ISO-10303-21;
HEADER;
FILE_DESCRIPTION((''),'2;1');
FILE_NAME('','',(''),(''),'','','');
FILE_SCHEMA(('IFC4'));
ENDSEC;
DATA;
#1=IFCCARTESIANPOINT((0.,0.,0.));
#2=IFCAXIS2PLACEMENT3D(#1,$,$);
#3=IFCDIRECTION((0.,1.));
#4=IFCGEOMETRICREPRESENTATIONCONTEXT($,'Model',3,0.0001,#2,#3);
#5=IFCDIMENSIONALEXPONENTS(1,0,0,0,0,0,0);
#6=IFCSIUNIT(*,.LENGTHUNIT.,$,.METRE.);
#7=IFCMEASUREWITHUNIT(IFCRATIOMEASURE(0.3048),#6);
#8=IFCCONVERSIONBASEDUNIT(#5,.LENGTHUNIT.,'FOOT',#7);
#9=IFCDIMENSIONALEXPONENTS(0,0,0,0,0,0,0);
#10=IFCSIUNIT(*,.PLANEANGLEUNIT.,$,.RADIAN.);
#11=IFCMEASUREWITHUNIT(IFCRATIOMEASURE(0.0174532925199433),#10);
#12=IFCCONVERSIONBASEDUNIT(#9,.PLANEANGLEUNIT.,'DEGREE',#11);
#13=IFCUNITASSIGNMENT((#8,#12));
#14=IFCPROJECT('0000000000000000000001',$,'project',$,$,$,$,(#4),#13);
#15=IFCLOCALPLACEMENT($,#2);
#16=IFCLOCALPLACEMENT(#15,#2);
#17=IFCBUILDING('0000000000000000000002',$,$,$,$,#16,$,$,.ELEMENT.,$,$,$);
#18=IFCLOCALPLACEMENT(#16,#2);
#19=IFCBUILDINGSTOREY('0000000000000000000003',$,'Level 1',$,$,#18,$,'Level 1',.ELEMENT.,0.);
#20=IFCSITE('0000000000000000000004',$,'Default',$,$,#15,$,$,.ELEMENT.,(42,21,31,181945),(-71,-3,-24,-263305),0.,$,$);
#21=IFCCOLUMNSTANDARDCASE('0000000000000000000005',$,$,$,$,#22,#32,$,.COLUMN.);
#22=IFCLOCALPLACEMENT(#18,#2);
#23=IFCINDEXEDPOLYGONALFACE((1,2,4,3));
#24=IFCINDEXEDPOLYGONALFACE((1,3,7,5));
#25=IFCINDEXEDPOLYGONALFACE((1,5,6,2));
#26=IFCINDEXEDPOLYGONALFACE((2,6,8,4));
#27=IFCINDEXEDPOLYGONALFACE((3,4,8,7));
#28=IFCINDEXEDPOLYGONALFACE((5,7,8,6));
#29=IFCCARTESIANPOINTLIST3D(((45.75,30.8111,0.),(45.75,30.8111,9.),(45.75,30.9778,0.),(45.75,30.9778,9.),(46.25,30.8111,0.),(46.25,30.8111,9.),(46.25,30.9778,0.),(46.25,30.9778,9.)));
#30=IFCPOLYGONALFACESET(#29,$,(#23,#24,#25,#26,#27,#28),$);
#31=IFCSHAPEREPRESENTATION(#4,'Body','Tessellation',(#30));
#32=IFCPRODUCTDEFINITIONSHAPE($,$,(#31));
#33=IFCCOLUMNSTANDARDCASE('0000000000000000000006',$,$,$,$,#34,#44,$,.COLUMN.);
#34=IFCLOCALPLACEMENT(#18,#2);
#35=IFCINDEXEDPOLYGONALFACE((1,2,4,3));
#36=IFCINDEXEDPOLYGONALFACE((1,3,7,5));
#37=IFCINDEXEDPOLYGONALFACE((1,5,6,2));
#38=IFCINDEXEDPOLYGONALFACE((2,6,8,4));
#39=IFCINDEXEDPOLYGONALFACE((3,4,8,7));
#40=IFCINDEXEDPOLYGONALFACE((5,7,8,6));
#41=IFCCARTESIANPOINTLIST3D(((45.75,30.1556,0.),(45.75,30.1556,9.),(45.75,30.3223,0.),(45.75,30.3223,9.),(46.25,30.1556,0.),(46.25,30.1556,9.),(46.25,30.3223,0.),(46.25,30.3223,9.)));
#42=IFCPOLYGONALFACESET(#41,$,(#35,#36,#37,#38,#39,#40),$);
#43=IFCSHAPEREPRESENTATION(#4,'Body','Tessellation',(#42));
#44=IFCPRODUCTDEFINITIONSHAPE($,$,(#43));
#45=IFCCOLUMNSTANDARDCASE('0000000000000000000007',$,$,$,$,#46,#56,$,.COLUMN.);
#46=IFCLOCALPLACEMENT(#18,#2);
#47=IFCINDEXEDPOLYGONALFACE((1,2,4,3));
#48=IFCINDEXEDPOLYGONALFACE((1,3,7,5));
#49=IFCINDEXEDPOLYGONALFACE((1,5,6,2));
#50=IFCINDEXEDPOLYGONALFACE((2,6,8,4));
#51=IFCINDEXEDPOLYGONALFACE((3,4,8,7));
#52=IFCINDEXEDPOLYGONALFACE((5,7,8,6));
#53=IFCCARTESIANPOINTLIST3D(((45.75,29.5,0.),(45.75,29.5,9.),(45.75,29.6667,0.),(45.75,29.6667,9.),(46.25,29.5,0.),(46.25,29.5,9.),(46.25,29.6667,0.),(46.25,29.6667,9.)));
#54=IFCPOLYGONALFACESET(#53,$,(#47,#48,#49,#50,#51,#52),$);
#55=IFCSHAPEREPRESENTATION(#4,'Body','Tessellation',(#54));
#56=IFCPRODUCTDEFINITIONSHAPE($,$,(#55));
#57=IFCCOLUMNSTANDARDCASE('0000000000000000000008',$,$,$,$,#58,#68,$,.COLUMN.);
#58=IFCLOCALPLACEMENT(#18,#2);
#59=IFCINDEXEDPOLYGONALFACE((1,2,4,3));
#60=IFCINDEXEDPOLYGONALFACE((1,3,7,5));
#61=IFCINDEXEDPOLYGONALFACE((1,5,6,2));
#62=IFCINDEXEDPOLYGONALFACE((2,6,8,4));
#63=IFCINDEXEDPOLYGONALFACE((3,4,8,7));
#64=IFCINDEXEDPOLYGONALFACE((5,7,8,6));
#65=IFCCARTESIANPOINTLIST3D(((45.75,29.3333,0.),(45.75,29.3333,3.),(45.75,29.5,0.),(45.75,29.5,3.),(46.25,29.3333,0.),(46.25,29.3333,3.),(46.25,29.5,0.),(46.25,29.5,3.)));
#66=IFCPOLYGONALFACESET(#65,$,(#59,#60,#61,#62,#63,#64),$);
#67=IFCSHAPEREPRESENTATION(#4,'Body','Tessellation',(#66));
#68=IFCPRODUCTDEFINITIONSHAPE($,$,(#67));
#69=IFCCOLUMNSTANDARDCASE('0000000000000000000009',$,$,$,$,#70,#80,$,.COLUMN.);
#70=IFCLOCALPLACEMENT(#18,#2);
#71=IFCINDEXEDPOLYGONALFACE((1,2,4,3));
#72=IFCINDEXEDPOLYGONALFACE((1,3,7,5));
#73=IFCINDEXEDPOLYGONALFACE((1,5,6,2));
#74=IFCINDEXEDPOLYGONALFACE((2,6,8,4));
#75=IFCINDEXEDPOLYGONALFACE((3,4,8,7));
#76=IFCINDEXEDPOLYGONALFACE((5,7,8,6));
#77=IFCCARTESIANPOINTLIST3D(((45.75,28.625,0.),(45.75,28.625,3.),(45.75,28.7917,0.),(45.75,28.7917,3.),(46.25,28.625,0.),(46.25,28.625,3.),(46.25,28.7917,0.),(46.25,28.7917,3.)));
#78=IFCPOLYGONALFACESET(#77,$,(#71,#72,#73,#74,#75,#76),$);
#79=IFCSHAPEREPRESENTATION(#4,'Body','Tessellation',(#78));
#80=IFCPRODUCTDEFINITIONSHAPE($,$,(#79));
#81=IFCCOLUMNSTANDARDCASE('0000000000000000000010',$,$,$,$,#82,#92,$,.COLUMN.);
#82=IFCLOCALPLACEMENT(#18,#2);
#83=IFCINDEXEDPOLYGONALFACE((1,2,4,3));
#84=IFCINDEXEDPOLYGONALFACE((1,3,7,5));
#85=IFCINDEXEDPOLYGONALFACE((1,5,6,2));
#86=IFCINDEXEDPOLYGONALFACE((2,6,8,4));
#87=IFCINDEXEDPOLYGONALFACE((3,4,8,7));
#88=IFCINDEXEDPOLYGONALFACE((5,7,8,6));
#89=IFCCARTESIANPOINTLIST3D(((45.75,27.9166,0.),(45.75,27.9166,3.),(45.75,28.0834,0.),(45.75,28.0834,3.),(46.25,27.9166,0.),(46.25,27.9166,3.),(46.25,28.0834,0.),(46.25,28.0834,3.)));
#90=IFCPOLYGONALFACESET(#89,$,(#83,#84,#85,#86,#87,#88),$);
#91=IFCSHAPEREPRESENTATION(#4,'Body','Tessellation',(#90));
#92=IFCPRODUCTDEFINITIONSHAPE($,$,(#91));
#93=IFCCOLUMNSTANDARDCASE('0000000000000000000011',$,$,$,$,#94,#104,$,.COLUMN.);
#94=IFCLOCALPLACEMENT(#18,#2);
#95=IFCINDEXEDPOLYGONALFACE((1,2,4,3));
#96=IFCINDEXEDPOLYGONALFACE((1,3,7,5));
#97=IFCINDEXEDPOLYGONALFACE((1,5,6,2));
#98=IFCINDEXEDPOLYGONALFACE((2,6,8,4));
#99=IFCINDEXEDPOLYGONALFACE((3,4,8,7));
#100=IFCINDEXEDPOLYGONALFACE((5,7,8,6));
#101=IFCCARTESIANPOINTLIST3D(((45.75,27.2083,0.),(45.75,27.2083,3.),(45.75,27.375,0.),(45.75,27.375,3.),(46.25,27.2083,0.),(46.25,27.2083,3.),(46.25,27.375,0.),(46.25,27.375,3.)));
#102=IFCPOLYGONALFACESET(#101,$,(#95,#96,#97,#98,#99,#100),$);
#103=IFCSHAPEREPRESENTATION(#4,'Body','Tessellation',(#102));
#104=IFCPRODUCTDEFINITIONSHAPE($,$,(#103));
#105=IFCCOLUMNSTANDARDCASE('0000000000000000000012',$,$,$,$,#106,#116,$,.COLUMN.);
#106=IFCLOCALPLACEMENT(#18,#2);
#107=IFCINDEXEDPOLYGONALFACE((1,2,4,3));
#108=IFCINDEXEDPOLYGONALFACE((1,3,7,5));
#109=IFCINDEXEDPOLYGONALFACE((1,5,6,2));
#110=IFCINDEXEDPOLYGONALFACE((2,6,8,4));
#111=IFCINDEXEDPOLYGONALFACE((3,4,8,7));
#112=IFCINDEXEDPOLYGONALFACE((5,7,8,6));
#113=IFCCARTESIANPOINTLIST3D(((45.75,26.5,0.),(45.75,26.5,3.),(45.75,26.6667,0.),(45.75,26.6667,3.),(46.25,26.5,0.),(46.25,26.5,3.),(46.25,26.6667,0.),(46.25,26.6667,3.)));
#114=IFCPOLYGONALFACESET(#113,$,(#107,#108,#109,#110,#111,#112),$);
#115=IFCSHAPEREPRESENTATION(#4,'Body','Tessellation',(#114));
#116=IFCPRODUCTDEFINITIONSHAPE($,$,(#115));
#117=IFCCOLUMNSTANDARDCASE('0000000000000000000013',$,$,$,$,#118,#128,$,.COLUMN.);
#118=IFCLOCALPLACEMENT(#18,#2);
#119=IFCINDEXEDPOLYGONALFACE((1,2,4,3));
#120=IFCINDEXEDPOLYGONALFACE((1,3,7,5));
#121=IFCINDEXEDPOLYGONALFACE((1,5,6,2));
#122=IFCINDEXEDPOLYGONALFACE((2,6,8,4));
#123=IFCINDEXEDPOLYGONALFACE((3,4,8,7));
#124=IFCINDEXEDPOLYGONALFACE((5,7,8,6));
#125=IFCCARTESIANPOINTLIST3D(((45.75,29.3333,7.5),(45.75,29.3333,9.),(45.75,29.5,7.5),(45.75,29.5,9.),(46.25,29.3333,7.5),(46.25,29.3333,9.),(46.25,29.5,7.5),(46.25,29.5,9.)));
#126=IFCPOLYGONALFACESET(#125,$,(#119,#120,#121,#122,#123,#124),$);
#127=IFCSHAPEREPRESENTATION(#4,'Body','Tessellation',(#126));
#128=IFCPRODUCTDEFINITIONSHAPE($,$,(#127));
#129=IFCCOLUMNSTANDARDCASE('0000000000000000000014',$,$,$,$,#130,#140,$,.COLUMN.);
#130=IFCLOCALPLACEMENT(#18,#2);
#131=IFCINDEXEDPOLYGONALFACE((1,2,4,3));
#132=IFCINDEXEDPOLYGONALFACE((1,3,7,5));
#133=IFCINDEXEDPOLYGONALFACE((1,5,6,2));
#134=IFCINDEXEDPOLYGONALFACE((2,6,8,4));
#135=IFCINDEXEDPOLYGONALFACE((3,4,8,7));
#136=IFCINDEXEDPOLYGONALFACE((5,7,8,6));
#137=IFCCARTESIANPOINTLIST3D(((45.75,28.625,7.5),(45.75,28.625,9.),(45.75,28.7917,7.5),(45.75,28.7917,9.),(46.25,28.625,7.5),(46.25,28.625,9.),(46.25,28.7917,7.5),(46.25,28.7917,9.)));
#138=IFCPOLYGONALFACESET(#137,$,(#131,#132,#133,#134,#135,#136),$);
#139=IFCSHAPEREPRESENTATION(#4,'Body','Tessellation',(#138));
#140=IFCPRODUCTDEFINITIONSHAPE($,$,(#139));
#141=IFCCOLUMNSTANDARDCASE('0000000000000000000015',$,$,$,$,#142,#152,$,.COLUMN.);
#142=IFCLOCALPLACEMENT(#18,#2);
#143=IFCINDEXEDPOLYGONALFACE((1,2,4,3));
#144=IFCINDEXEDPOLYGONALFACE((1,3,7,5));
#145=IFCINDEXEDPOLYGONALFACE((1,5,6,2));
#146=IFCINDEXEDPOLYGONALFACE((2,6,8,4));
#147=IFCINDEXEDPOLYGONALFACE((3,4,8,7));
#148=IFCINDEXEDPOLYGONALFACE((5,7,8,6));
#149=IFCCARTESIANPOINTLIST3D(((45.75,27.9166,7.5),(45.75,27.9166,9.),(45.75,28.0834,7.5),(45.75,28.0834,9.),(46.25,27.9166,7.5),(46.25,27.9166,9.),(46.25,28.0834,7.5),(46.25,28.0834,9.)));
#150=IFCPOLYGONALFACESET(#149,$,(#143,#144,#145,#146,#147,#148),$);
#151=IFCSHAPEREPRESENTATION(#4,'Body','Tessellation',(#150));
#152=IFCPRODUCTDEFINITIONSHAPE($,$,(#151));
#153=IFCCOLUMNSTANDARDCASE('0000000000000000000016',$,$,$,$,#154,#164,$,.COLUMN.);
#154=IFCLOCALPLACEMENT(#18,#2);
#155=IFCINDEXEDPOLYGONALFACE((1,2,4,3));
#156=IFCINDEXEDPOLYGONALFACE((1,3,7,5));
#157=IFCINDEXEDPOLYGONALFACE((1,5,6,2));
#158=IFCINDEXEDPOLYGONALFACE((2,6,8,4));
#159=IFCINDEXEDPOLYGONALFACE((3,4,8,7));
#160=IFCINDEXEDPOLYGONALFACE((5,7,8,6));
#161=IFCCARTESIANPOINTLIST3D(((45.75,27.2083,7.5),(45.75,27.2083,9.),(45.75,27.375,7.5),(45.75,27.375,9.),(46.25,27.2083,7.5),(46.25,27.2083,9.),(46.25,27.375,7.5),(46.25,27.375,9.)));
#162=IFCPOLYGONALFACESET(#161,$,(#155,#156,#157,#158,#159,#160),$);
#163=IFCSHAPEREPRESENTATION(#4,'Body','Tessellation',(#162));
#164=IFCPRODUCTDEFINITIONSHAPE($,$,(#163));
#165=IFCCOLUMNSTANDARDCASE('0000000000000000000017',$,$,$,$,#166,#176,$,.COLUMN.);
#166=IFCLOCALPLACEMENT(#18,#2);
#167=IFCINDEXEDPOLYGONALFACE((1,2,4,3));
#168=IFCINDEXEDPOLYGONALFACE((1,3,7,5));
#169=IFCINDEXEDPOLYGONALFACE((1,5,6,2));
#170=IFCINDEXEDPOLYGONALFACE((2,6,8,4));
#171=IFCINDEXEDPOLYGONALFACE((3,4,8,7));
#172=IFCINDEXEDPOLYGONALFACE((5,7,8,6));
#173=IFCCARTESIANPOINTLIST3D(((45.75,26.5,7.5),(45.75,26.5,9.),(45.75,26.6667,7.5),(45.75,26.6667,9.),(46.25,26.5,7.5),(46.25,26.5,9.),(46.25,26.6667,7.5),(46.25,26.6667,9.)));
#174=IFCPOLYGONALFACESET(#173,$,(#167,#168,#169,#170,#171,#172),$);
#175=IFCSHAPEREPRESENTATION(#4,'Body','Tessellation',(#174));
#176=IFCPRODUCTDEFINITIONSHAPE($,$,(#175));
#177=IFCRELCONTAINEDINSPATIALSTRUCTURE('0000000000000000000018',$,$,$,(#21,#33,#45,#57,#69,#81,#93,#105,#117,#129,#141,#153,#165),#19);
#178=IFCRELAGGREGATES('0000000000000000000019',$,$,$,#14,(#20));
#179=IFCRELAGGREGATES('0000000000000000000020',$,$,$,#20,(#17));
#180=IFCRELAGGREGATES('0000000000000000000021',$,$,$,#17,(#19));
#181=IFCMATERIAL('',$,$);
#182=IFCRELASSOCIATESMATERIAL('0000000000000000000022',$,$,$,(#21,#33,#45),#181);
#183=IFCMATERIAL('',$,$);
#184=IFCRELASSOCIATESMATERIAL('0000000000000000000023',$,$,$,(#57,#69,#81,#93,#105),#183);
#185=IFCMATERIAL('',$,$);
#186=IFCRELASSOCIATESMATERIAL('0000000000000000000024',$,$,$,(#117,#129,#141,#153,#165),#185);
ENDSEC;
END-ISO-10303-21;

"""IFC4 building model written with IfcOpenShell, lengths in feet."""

from ifc_helpers import new_model, entity, si_unit, converted_unit, direction, frame, origin, place, context, project, spatial, rectangle, extrude, material, element, save


model = new_model("IFC4")

# Units and contexts
model_context = context("Model", 3, precision=0.0001, world=origin(), true_north=direction((0.0, 1.0)))
ifc_project = project(units=[converted_unit("LENGTHUNIT", "FOOT", entity("IfcRatioMeasure", 0.3048), si_unit("LENGTHUNIT", "METRE"), dimensions=[1, 0, 0, 0, 0, 0, 0]), converted_unit("PLANEANGLEUNIT", "DEGREE", entity("IfcRatioMeasure", 0.0174532925199433), si_unit("PLANEANGLEUNIT", "RADIAN"), dimensions=[0, 0, 0, 0, 0, 0, 0])], contexts=[model_context])

# Site, building, storey
site_placement = place(None, origin())
site = spatial("IfcSite", under=ifc_project, at=site_placement, Name="Default", CompositionType="ELEMENT", RefLatitude=(42, 21, 31, 181945), RefLongitude=(-71, -3, -24, -263305), RefElevation=0.0)
building_placement = place(site_placement, origin())
building = spatial("IfcBuilding", under=site, at=building_placement, CompositionType="ELEMENT")
storey_placement = place(building_placement, origin())
storey = spatial("IfcBuildingStorey", under=building, at=storey_placement, Name="Level 1", LongName="Level 1", CompositionType="ELEMENT", Elevation=0.0)

# Columns
ifc_material_1 = material(Name="")
placement = place(storey_placement, frame((46.0, 46.25, 0.0), z_axis=(0.0, 0.0, 1.0), x_axis=(0.0, -1.0, 0.0)))
for number, where, z_axis, x_axis in (
    (1, (15.3555, 0.0, 0.0), (0.0, 0.0, 1.0), (1.0, 0.0, 0.0)),
    (2, (16.0111, 0.0, 0.0), (0.0, 0.0, 1.0), (1.0, 0.0, 0.0)),
    (3, (16.6667, 0.0, 0.0), (0.0, 0.0, 1.0), (1.0, 0.0, 0.0)),
):
    element("IfcColumnStandardCase", number, at=place(placement, frame(where, z_axis=z_axis, x_axis=x_axis)), inside=storey, material=ifc_material_1, PredefinedType="COLUMN", context=model_context, shape_type="SweptSolid", body=[
        extrude(rectangle(XDim=0.1667, YDim=0.5), origin(), (0.0, 0.0, 1.0), 9.0),
    ])
ifc_material_2 = material(Name="")
for number, where, z_axis, x_axis in (
    (4, (16.8334, 0.0, 0.0), (0.0, 0.0, 1.0), (1.0, 0.0, 0.0)),
    (5, (17.5417, 0.0, 0.0), (0.0, 0.0, 1.0), (1.0, 0.0, 0.0)),
    (6, (18.25, 0.0, 0.0), (0.0, 0.0, 1.0), (1.0, 0.0, 0.0)),
    (7, (18.9583, 0.0, 0.0), (0.0, 0.0, 1.0), (1.0, 0.0, 0.0)),
    (8, (19.6667, 0.0, 0.0), (0.0, 0.0, 1.0), (1.0, 0.0, 0.0)),
):
    element("IfcColumnStandardCase", number, at=place(placement, frame(where, z_axis=z_axis, x_axis=x_axis)), inside=storey, material=ifc_material_2, PredefinedType="COLUMN", context=model_context, shape_type="SweptSolid", body=[
        extrude(rectangle(XDim=0.1667, YDim=0.5), origin(), (0.0, 0.0, 1.0), 3.0),
    ])
ifc_material_3 = material(Name="")
for number, where, z_axis, x_axis in (
    (9, (16.8334, 0.0, 7.5), (0.0, 0.0, 1.0), (1.0, 0.0, 0.0)),
    (10, (17.5417, 0.0, 7.5), (0.0, 0.0, 1.0), (1.0, 0.0, 0.0)),
    (11, (18.25, 0.0, 7.5), (0.0, 0.0, 1.0), (1.0, 0.0, 0.0)),
    (12, (18.9583, 0.0, 7.5), (0.0, 0.0, 1.0), (1.0, 0.0, 0.0)),
    (13, (19.6667, 0.0, 7.5), (0.0, 0.0, 1.0), (1.0, 0.0, 0.0)),
):
    element("IfcColumnStandardCase", number, at=place(placement, frame(where, z_axis=z_axis, x_axis=x_axis)), inside=storey, material=ifc_material_3, PredefinedType="COLUMN", context=model_context, shape_type="SweptSolid", body=[
        extrude(rectangle(XDim=0.1667, YDim=0.5), origin(), (0.0, 0.0, 1.0), 1.5),
    ])

save(model, "model.ifc")
